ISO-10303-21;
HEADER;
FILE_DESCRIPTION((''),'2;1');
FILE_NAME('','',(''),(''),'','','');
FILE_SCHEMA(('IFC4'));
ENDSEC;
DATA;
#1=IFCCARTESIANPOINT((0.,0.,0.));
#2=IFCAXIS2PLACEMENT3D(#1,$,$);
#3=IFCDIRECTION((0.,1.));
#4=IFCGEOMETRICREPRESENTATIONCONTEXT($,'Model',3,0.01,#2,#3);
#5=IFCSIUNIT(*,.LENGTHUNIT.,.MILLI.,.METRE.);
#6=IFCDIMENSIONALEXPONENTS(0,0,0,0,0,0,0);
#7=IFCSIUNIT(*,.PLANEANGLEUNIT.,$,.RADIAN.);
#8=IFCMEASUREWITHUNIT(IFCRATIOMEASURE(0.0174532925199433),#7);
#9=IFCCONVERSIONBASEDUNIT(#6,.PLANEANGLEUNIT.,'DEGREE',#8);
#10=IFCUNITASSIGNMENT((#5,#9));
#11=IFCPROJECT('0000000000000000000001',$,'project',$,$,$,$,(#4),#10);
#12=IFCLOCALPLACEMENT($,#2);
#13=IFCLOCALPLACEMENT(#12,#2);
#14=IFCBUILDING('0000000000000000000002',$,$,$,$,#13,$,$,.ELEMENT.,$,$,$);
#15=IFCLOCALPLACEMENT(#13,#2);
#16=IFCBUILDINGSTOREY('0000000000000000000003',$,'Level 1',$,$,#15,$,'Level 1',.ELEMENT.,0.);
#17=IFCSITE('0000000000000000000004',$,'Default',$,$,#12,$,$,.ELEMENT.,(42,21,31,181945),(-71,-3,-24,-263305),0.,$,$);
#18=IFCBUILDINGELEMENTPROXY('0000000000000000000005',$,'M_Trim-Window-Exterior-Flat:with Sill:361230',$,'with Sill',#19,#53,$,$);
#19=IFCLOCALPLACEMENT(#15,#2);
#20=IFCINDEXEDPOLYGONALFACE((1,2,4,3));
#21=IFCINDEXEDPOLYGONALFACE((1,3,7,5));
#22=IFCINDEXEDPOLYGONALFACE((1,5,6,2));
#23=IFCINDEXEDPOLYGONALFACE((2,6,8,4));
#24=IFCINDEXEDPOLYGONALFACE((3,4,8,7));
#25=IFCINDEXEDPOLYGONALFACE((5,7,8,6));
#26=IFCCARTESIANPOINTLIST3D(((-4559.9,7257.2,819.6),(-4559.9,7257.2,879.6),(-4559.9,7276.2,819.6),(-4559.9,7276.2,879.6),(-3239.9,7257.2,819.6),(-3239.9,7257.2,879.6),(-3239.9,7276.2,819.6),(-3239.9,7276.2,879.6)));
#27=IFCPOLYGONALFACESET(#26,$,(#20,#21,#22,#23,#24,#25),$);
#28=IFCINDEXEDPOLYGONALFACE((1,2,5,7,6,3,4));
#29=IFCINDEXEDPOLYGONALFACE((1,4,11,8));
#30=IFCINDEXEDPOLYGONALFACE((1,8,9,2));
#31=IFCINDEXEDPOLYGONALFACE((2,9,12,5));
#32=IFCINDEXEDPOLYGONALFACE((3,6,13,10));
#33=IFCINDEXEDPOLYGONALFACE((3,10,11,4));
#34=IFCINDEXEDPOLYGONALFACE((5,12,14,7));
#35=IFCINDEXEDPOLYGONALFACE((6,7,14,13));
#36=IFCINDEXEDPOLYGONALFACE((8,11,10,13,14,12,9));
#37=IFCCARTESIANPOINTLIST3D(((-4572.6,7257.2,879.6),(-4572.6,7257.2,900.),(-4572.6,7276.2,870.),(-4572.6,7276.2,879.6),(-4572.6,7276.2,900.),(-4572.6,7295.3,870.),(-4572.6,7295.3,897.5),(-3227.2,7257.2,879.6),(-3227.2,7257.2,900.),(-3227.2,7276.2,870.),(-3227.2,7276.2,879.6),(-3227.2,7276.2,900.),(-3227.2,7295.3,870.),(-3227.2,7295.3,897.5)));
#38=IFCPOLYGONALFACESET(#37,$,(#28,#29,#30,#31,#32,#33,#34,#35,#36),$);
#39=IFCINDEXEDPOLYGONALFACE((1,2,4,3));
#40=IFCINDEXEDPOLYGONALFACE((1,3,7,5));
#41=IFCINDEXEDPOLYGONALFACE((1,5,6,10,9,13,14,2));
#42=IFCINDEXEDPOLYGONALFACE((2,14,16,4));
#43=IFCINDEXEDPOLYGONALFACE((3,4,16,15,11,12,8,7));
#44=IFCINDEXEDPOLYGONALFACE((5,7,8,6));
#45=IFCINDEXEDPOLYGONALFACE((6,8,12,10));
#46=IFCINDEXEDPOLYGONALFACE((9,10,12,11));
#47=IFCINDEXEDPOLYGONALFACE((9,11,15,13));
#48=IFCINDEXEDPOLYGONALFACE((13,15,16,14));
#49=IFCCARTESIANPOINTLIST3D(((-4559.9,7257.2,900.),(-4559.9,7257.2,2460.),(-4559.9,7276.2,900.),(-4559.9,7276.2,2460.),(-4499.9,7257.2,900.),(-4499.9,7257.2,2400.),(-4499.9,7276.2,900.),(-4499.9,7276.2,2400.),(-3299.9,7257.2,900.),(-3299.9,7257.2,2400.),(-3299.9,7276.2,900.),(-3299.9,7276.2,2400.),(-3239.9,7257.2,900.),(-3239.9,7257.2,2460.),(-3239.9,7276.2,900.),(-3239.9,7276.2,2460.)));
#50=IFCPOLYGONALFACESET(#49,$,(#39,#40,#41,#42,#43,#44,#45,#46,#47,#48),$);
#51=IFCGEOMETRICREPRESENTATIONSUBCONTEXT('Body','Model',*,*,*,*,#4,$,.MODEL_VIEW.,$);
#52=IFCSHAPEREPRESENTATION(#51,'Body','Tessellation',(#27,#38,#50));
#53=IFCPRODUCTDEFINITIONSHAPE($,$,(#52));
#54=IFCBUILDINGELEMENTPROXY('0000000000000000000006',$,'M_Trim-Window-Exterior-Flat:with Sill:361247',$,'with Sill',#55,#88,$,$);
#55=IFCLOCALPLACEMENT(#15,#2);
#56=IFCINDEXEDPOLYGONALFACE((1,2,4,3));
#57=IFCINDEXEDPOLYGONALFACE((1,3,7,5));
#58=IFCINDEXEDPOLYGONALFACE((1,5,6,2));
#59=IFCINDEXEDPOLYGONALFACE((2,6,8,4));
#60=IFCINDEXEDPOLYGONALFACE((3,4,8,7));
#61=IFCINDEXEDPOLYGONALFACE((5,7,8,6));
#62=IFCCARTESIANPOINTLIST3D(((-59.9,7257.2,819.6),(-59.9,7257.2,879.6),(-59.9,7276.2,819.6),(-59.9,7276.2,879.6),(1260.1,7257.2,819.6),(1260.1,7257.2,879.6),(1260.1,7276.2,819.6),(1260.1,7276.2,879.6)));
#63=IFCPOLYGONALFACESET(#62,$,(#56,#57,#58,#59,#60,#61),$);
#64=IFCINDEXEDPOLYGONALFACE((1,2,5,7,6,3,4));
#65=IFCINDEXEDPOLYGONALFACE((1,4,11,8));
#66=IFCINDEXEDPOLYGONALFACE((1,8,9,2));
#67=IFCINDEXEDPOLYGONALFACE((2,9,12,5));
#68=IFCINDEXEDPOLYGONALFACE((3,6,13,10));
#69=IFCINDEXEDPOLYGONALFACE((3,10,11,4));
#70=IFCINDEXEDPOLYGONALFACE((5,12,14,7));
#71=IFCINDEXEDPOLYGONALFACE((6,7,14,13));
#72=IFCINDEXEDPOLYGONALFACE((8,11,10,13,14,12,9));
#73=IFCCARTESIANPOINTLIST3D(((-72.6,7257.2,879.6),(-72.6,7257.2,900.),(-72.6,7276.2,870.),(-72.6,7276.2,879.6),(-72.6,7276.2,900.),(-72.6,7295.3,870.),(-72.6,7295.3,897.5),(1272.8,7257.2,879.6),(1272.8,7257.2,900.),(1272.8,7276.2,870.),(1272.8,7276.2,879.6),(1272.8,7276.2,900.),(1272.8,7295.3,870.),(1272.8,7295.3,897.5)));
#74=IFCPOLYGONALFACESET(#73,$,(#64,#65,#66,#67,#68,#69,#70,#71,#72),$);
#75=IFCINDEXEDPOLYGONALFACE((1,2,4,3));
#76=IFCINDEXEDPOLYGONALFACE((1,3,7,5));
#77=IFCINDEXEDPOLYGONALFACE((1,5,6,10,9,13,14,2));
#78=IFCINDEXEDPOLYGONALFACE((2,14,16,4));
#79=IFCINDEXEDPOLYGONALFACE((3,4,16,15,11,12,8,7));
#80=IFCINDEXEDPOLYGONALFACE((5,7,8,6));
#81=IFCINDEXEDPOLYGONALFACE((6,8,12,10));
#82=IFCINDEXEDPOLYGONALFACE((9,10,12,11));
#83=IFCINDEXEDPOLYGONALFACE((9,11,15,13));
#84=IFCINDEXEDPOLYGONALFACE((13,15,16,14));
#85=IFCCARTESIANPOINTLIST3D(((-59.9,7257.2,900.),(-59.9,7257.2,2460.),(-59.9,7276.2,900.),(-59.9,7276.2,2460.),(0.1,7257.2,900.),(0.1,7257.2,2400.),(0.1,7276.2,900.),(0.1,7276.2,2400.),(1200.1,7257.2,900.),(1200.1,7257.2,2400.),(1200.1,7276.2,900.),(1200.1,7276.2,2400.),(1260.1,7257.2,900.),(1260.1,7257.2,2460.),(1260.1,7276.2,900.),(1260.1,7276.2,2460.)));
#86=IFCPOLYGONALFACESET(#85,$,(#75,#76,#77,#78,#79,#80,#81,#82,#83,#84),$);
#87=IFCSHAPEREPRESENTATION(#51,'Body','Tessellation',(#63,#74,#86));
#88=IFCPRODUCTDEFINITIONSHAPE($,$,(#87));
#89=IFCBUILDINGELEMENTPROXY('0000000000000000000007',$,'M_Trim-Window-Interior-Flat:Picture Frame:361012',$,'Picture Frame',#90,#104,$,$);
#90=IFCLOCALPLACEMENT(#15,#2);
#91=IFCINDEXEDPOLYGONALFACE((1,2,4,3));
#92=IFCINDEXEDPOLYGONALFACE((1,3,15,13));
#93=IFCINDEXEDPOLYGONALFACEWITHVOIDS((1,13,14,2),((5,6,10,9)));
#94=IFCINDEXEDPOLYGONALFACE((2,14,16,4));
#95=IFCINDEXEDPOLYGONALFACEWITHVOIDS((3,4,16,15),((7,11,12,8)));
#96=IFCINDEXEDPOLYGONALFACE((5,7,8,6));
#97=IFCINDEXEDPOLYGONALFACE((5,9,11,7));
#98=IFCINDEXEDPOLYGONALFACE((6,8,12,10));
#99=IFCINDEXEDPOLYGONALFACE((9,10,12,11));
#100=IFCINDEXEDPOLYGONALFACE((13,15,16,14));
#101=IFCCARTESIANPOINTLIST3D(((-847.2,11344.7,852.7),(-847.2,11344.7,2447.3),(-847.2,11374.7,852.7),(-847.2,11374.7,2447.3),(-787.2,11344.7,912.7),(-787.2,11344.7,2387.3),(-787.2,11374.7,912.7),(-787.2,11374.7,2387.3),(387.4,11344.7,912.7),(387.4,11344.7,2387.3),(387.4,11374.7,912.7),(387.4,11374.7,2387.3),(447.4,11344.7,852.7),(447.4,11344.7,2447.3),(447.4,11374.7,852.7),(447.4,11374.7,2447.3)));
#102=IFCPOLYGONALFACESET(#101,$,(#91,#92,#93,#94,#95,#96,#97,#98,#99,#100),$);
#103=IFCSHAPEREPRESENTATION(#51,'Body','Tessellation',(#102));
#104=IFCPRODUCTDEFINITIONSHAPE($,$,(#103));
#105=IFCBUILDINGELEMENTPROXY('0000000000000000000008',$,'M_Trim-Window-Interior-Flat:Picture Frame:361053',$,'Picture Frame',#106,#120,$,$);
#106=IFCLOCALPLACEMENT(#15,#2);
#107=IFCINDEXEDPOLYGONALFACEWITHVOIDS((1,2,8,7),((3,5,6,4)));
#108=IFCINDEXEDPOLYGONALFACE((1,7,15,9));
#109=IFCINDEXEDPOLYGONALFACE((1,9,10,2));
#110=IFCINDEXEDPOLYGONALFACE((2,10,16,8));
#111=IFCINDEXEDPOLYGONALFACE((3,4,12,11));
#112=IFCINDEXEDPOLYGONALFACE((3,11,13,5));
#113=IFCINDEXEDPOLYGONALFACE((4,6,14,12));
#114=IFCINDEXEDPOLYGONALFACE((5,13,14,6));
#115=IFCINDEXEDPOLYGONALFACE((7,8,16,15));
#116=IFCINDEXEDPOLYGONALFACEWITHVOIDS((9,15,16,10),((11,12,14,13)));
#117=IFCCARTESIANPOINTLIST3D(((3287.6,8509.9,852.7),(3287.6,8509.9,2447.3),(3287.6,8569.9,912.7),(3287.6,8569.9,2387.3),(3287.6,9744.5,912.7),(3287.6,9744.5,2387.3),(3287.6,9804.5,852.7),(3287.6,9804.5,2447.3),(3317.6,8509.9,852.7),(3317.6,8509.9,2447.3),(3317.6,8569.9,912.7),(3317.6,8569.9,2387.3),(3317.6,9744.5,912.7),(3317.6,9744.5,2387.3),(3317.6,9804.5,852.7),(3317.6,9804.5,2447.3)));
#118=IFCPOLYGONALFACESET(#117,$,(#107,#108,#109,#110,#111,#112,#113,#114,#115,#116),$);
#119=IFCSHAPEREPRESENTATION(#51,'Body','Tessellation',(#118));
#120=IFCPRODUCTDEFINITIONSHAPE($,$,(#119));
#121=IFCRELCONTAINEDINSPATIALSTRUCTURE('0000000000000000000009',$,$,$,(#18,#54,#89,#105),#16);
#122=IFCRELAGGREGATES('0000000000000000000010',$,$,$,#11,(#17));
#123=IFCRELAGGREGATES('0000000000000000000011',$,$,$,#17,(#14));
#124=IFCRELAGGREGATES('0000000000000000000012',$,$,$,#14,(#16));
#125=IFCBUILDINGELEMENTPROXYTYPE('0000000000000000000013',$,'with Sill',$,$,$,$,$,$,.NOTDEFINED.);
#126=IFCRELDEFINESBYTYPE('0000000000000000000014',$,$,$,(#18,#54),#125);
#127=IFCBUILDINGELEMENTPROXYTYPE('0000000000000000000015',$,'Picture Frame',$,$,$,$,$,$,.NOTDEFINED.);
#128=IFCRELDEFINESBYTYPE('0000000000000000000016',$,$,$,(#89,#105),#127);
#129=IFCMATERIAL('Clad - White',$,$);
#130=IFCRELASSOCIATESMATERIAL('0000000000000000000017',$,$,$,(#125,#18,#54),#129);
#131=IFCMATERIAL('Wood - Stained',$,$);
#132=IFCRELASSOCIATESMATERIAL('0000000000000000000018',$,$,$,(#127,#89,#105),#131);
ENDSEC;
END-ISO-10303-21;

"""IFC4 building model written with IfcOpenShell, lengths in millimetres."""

from ifc_helpers import new_model, entity, si_unit, converted_unit, direction, frame, frame_2d, origin, place, context, subcontext, project, spatial, polyline, rectangle, outline, extrude, source, transform, mapped, material, type_object, type_shapes, element, save


model = new_model("IFC4")

# Units and contexts
model_context = context("Model", 3, precision=0.01, world=origin(), true_north=direction((0.0, 1.0)))
body_context = subcontext(model_context, "Body", "Model", "MODEL_VIEW")
ifc_project = project(units=[si_unit("LENGTHUNIT", "METRE", prefix="MILLI"), converted_unit("PLANEANGLEUNIT", "DEGREE", entity("IfcRatioMeasure", 0.0174532925199433), si_unit("PLANEANGLEUNIT", "RADIAN"), dimensions=[0, 0, 0, 0, 0, 0, 0])], contexts=[model_context])

# Site, building, storey
site_placement = place(None, origin())
site = spatial("IfcSite", under=ifc_project, at=site_placement, Name="Default", CompositionType="ELEMENT", RefLatitude=(42, 21, 31, 181945), RefLongitude=(-71, -3, -24, -263305), RefElevation=0.0)
building_placement = place(site_placement, origin())
building = spatial("IfcBuilding", under=site, at=building_placement, CompositionType="ELEMENT")
storey_placement = place(building_placement, origin())
storey = spatial("IfcBuildingStorey", under=building, at=storey_placement, Name="Level 1", LongName="Level 1", CompositionType="ELEMENT", Elevation=0.0)

# Building element proxies
ifc_material_1 = material(Name="Clad - White")
ifc_material_2 = material(Name="Wood - Stained")
building_element_proxy_type_1 = type_object("IfcBuildingElementProxyType", Name="with Sill", PredefinedType="NOTDEFINED", material=ifc_material_1)
shared_shape_1 = source(origin(), body_context, "Body", "SweptSolid", [
    extrude(rectangle(XDim=1320.0, YDim=60.0, at=frame_2d((0.0, 0.0), x_axis=(1.0, 0.0))), frame((0.0, -1550.4, 0.0), z_axis=(0.0, 0.0, 1.0), x_axis=(-1.0, 0.0, 0.0)), (0.0, 0.0, 1.0), 19.1),
    extrude(outline(polyline([(-19.0, -15.2), (0.0, -15.2), (0.0, -5.7), (19.0, -5.7), (19.0, 14.8), (0.0, 14.8), (-19.0, 12.3), (-19.0, -15.2)])), frame((-672.7, -1514.8, 19.0), z_axis=(1.0, 0.0, 0.0), x_axis=(0.0, 0.0, -1.0)), (0.0, 0.0, 1.0), 1345.4),
    extrude(outline(polyline([(-795.0, -660.0), (765.0, -660.0), (765.0, -600.0), (-735.0, -600.0), (-735.0, 600.0), (765.0, 600.0), (765.0, 660.0), (-795.0, 660.0), (-795.0, -660.0)])), frame((0.0, -735.0, 0.0), z_axis=(0.0, 0.0, 1.0), x_axis=(0.0, -1.0, 0.0)), (0.0, 0.0, 1.0), 19.1),
])
type_shapes(building_element_proxy_type_1, [shared_shape_1])
for number, where, z_axis, x_axis, name in (
    (1, (-3899.9, 7257.2, 2400.0), (0.0, 1.0, 0.0), (-1.0, 0.0, 0.0), "M_Trim-Window-Exterior-Flat:with Sill:361230"),
    (2, (600.1, 7257.2, 2400.0), (0.0, 1.0, 0.0), (-1.0, 0.0, 0.0), "M_Trim-Window-Exterior-Flat:with Sill:361247"),
):
    element("IfcBuildingElementProxy", number, at=place(storey_placement, frame(where, z_axis=z_axis, x_axis=x_axis)), inside=storey, type_object=building_element_proxy_type_1, material=ifc_material_1, Name=name, ObjectType="with Sill", context=body_context, shape_type="MappedRepresentation", body=[
        mapped(shared_shape_1, transform((0.0, 0.0, 0.0), scale=1.0)),
    ])
building_element_proxy_type_2 = type_object("IfcBuildingElementProxyType", Name="Picture Frame", PredefinedType="NOTDEFINED", material=ifc_material_2)
shared_shape_2 = source(origin(), body_context, "Body", "SweptSolid", [
    extrude(outline(polyline([(-647.3, -797.3), (647.3, -797.3), (647.3, 797.3), (-647.3, 797.3), (-647.3, -797.3)]), holes=[polyline([(-587.3, -737.3), (-587.3, 737.3), (587.3, 737.3), (587.3, -737.3), (-587.3, -737.3)])]), frame((0.0, -750.0, 0.0), z_axis=(0.0, 0.0, 1.0), x_axis=(-1.0, 0.0, 0.0)), (0.0, 0.0, 1.0), 30.0),
])
type_shapes(building_element_proxy_type_2, [shared_shape_2])
for number, where, z_axis, x_axis, name in (
    (3, (-199.9, 11344.7, 2400.0), (0.0, 1.0, 0.0), (-1.0, 0.0, 0.0), "M_Trim-Window-Interior-Flat:Picture Frame:361012"),
    (4, (3287.6, 9157.2, 2400.0), (1.0, 0.0, 0.0), (0.0, 1.0, 0.0), "M_Trim-Window-Interior-Flat:Picture Frame:361053"),
):
    element("IfcBuildingElementProxy", number, at=place(storey_placement, frame(where, z_axis=z_axis, x_axis=x_axis)), inside=storey, type_object=building_element_proxy_type_2, material=ifc_material_2, Name=name, ObjectType="Picture Frame", context=body_context, shape_type="MappedRepresentation", body=[
        mapped(shared_shape_2, transform((0.0, 0.0, 0.0), scale=1.0)),
    ])

save(model, "model.ifc")
